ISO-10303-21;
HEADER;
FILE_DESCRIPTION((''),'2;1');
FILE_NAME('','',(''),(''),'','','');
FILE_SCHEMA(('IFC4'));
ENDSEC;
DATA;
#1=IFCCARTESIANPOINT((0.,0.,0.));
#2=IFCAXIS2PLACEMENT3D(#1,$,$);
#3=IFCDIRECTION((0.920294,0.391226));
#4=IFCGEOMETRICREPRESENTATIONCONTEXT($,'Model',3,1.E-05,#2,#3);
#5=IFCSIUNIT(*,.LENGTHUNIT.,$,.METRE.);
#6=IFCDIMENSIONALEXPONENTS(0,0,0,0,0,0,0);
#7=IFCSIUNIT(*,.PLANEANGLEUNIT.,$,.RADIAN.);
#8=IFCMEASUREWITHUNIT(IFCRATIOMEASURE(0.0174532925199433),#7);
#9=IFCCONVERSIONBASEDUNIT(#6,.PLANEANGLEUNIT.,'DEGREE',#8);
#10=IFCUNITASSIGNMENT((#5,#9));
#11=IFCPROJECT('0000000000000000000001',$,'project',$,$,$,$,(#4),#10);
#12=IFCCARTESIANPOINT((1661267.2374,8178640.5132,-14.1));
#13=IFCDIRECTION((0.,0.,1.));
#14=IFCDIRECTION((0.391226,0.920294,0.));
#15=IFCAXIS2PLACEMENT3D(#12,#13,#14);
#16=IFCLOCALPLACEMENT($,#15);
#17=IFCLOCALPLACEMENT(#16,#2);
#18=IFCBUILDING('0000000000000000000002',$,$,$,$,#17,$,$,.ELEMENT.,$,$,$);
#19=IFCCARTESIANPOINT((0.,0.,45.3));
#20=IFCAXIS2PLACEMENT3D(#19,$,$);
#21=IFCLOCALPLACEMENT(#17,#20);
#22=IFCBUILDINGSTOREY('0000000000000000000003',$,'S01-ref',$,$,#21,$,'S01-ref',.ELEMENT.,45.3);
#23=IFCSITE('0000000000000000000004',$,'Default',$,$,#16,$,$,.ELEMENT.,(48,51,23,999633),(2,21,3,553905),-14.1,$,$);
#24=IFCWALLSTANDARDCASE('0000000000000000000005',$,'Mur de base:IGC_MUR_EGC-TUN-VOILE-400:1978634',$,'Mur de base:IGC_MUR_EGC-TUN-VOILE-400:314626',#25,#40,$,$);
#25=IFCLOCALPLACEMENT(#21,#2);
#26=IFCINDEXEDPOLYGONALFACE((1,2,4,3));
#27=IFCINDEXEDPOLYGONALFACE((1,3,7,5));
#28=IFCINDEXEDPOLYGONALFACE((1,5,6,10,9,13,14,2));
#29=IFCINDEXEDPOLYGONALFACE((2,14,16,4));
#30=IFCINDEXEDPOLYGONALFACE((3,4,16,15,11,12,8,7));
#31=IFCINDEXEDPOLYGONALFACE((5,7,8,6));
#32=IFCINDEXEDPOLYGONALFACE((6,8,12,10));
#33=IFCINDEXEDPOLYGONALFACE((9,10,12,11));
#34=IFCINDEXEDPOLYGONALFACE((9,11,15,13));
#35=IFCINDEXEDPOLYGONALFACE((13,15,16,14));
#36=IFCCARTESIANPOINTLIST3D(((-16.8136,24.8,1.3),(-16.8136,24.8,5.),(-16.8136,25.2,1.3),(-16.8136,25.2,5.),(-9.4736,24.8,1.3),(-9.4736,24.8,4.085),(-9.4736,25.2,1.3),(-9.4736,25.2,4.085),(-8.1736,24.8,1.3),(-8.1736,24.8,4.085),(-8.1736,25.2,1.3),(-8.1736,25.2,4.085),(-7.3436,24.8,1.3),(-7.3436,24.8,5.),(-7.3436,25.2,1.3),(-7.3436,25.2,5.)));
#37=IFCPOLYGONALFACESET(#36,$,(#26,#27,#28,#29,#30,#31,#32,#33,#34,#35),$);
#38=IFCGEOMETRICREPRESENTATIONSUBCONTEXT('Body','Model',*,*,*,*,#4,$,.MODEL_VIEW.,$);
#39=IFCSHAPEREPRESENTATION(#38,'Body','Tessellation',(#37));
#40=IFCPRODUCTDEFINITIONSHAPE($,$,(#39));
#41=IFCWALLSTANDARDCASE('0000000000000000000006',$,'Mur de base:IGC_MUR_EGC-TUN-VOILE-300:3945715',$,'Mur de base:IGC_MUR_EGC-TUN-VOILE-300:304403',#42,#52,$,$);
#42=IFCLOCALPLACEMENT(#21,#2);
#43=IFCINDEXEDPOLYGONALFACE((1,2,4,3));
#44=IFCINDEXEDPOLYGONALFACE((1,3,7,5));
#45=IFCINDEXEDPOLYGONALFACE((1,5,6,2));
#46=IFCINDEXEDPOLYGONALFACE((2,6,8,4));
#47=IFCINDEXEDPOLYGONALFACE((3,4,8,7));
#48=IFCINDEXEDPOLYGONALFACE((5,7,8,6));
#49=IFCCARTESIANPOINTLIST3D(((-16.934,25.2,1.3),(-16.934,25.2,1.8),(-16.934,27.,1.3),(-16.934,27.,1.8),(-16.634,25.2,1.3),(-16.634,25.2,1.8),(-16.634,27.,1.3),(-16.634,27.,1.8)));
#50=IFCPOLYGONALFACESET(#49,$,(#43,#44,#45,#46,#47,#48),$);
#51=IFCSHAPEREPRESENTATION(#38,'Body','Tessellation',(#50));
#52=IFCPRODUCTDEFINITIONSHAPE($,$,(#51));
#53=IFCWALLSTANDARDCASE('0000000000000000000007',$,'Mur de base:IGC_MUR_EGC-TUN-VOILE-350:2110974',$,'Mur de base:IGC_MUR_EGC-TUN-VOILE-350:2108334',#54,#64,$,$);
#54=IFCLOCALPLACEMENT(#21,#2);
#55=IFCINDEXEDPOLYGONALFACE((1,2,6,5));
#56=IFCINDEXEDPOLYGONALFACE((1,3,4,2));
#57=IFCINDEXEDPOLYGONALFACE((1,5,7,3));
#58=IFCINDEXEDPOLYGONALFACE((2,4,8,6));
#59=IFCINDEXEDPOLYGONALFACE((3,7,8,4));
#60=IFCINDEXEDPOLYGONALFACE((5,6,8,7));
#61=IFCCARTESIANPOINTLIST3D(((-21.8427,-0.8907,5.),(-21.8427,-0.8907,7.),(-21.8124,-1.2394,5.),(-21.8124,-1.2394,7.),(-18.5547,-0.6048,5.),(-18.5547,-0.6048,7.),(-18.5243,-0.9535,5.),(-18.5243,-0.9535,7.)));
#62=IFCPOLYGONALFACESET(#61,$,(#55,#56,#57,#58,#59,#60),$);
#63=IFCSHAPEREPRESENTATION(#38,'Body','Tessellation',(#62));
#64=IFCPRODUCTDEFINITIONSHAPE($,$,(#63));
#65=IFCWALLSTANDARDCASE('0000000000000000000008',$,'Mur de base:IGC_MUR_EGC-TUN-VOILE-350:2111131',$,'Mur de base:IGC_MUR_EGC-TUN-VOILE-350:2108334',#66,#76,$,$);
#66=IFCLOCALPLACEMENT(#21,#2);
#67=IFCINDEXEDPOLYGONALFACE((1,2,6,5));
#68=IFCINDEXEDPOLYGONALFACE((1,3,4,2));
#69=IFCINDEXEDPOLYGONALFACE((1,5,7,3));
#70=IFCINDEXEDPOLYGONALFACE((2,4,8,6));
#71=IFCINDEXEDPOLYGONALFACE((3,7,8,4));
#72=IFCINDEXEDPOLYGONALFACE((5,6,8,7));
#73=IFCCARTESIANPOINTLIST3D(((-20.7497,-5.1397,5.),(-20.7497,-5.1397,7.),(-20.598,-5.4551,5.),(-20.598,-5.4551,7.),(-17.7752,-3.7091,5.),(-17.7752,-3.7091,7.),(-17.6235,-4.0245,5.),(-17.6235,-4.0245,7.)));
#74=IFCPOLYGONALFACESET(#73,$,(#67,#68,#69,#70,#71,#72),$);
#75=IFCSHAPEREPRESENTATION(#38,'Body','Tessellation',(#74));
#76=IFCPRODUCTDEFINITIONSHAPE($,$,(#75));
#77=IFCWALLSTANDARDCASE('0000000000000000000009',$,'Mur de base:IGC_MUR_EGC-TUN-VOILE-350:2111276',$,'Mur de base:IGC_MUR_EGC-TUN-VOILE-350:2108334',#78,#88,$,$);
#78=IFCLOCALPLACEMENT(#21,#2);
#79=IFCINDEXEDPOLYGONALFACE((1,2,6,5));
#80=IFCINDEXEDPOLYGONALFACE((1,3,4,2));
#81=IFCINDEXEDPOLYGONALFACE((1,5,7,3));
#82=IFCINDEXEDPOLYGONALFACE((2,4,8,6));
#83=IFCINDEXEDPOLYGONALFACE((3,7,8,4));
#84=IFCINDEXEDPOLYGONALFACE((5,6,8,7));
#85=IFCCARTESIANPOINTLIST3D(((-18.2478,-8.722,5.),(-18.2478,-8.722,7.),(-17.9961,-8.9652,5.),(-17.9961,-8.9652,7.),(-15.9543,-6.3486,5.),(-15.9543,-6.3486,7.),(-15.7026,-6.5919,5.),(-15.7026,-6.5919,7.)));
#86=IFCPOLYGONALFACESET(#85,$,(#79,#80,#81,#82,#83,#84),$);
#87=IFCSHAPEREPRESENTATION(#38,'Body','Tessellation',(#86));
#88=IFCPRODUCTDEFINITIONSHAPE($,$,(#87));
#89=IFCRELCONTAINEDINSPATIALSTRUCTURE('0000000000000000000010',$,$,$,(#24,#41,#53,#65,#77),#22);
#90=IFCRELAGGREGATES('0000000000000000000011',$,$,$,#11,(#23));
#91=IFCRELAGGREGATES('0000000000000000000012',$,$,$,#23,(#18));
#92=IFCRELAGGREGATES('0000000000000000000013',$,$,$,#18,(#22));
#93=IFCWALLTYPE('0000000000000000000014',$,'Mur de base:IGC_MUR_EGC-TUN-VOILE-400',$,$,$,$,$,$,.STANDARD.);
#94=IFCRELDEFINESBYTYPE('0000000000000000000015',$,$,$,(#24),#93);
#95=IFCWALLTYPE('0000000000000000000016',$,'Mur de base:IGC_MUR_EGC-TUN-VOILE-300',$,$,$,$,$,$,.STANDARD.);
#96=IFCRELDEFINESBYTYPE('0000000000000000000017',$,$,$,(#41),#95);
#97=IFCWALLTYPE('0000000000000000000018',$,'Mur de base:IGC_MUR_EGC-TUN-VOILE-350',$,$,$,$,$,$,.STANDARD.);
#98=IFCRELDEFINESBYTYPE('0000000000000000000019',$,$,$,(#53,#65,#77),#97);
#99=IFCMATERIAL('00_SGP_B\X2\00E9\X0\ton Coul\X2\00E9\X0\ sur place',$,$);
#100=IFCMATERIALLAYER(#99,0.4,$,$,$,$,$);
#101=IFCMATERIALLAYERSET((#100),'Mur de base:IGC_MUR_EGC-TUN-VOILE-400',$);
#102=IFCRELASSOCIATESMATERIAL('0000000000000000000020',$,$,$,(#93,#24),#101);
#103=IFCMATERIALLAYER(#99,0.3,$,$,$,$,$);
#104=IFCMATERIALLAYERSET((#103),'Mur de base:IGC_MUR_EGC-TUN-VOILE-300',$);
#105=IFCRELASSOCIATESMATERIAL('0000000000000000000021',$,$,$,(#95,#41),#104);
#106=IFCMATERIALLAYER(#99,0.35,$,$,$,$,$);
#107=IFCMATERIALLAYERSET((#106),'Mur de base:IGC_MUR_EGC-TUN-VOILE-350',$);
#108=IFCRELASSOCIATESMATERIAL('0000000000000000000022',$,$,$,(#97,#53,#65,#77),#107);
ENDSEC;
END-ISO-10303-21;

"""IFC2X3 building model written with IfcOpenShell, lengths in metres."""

from ifc_helpers import new_model, entity, si_unit, converted_unit, direction, frame, frame_2d, origin, place, context, subcontext, project, spatial, rectangle, extrude, material, layer, layer_set, layer_usage, type_object, element, save


model = new_model("IFC2X3")

# Units and contexts
model_context = context("Model", 3, precision=1e-05, world=origin(), true_north=direction((0.920294, 0.391226)))
body_context = subcontext(model_context, "Body", "Model", "MODEL_VIEW")
ifc_project = project(units=[si_unit("LENGTHUNIT", "METRE"), converted_unit("PLANEANGLEUNIT", "DEGREE", entity("IfcRatioMeasure", 0.0174532925199433), si_unit("PLANEANGLEUNIT", "RADIAN"), dimensions=[0, 0, 0, 0, 0, 0, 0])], contexts=[model_context])

# Site, building, storey
site_placement = place(None, frame((1661267.2374, 8178640.5132, -14.1), z_axis=(0.0, 0.0, 1.0), x_axis=(0.391226, 0.920294, 0.0)))
site = spatial("IfcSite", under=ifc_project, at=site_placement, Name="Default", CompositionType="ELEMENT", RefLatitude=(48, 51, 23, 999633), RefLongitude=(2, 21, 3, 553905), RefElevation=-14.1)
building_placement = place(site_placement, origin())
building = spatial("IfcBuilding", under=site, at=building_placement, CompositionType="ELEMENT")
storey_placement = place(building_placement, frame((0.0, 0.0, 45.3)))
storey = spatial("IfcBuildingStorey", under=building, at=storey_placement, Name="S01-ref", LongName="S01-ref", CompositionType="ELEMENT", Elevation=45.3)

# Shared definitions
ifc_material_1 = material(Name="00_SGP_Béton Coulé sur place")

# Shared definitions
ifc_layer_1 = layer(ifc_material_1, 0.4)
ifc_layer_set_1 = layer_set([ifc_layer_1], Name="Mur de base:IGC_MUR_EGC-TUN-VOILE-400")
wall_type_1 = type_object("IfcWallType", Name="Mur de base:IGC_MUR_EGC-TUN-VOILE-400", PredefinedType="STANDARD", material=ifc_layer_set_1)

# Wall, opening
ifc_layer_usage_1 = layer_usage(ifc_layer_set_1, "AXIS2", "NEGATIVE", 0.2)
wall_1_placement = place(storey_placement, frame((-16.8136, 25.0, 1.3)))
wall_1 = element("IfcWallStandardCase", 1, at=wall_1_placement, inside=storey, type_object=wall_type_1, material=ifc_layer_usage_1, Name="Mur de base:IGC_MUR_EGC-TUN-VOILE-400:1978634", ObjectType="Mur de base:IGC_MUR_EGC-TUN-VOILE-400:314626", context=body_context, shape_type="SweptSolid", body=[
    extrude(rectangle(XDim=9.47, YDim=0.4, at=frame_2d((4.735, 0.0), x_axis=(-1.0, 0.0))), origin(), (0.0, 0.0, 1.0), 3.7),
])
opening_1_placement = place(wall_1_placement, origin())
element("IfcOpeningElement", 2, at=opening_1_placement, cuts=wall_1, ObjectType="Opening", context=body_context, shape_type="SweptSolid", body=[
    extrude(rectangle(XDim=2.785, YDim=1.3, at=frame_2d((0.0, 0.0), x_axis=(0.0, 1.0))), frame((7.99, -1.724, 1.3925), z_axis=(0.0, 1.0, 0.0), x_axis=(1.0, 0.0, 0.0)), (0.0, 0.0, 1.0), 3.048),
])

# Walls
ifc_layer_2 = layer(ifc_material_1, 0.3)
ifc_layer_set_2 = layer_set([ifc_layer_2], Name="Mur de base:IGC_MUR_EGC-TUN-VOILE-300")
ifc_layer_usage_2 = layer_usage(ifc_layer_set_2, "AXIS2", "NEGATIVE", 0.15)
wall_type_2 = type_object("IfcWallType", Name="Mur de base:IGC_MUR_EGC-TUN-VOILE-300", PredefinedType="STANDARD", material=ifc_layer_set_2)
wall_2_placement = place(storey_placement, frame((-16.784, 25.2, 1.3), z_axis=(0.0, 0.0, 1.0), x_axis=(0.0, 1.0, 0.0)))
element("IfcWallStandardCase", 3, at=wall_2_placement, inside=storey, type_object=wall_type_2, material=ifc_layer_usage_2, Name="Mur de base:IGC_MUR_EGC-TUN-VOILE-300:3945715", ObjectType="Mur de base:IGC_MUR_EGC-TUN-VOILE-300:304403", context=body_context, shape_type="SweptSolid", body=[
    extrude(rectangle(XDim=1.8, YDim=0.3, at=frame_2d((0.9, 0.0), x_axis=(-1.0, 0.0))), origin(), (0.0, 0.0, 1.0), 0.5),
])
ifc_layer_3 = layer(ifc_material_1, 0.35)
ifc_layer_set_3 = layer_set([ifc_layer_3], Name="Mur de base:IGC_MUR_EGC-TUN-VOILE-350")
ifc_layer_usage_3 = layer_usage(ifc_layer_set_3, "AXIS2", "POSITIVE", -0.175)
wall_type_3 = type_object("IfcWallType", Name="Mur de base:IGC_MUR_EGC-TUN-VOILE-350", PredefinedType="STANDARD", material=ifc_layer_set_3)
wall_3_placement = place(storey_placement, frame((-18.5395, -0.7792, 5.0), z_axis=(0.0, 0.0, 1.0), x_axis=(-0.996243, -0.086607, 0.0)))
element("IfcWallStandardCase", 4, at=wall_3_placement, inside=storey, type_object=wall_type_3, material=ifc_layer_usage_3, Name="Mur de base:IGC_MUR_EGC-TUN-VOILE-350:2110974", ObjectType="Mur de base:IGC_MUR_EGC-TUN-VOILE-350:2108334", context=body_context, shape_type="SweptSolid", body=[
    extrude(rectangle(XDim=3.3005, YDim=0.35, at=frame_2d((1.6502, 0.0), x_axis=(-1.0, 0.0))), origin(), (0.0, 0.0, 1.0), 2.0),
])
ifc_layer_usage_4 = layer_usage(ifc_layer_set_3, "AXIS2", "POSITIVE", -0.175)
wall_4_placement = place(storey_placement, frame((-17.6993, -3.8668, 5.0), z_axis=(0.0, 0.0, 1.0), x_axis=(-0.901191, -0.433422, 0.0)))
element("IfcWallStandardCase", 5, at=wall_4_placement, inside=storey, type_object=wall_type_3, material=ifc_layer_usage_4, Name="Mur de base:IGC_MUR_EGC-TUN-VOILE-350:2111131", ObjectType="Mur de base:IGC_MUR_EGC-TUN-VOILE-350:2108334", context=body_context, shape_type="SweptSolid", body=[
    extrude(rectangle(XDim=3.3006, YDim=0.35, at=frame_2d((1.6503, 0.0), x_axis=(-1.0, 0.0))), origin(), (0.0, 0.0, 1.0), 2.0),
])
ifc_layer_usage_5 = layer_usage(ifc_layer_set_3, "AXIS2", "POSITIVE", -0.175)
wall_5_placement = place(storey_placement, frame((-15.8285, -6.4703, 5.0), z_axis=(0.0, 0.0, 1.0), x_axis=(-0.694907, -0.7191, 0.0)))
element("IfcWallStandardCase", 6, at=wall_5_placement, inside=storey, type_object=wall_type_3, material=ifc_layer_usage_5, Name="Mur de base:IGC_MUR_EGC-TUN-VOILE-350:2111276", ObjectType="Mur de base:IGC_MUR_EGC-TUN-VOILE-350:2108334", context=body_context, shape_type="SweptSolid", body=[
    extrude(rectangle(XDim=3.3004, YDim=0.35, at=frame_2d((1.6502, 0.0), x_axis=(-1.0, 0.0))), origin(), (0.0, 0.0, 1.0), 2.0),
])

save(model, "model.ifc")
